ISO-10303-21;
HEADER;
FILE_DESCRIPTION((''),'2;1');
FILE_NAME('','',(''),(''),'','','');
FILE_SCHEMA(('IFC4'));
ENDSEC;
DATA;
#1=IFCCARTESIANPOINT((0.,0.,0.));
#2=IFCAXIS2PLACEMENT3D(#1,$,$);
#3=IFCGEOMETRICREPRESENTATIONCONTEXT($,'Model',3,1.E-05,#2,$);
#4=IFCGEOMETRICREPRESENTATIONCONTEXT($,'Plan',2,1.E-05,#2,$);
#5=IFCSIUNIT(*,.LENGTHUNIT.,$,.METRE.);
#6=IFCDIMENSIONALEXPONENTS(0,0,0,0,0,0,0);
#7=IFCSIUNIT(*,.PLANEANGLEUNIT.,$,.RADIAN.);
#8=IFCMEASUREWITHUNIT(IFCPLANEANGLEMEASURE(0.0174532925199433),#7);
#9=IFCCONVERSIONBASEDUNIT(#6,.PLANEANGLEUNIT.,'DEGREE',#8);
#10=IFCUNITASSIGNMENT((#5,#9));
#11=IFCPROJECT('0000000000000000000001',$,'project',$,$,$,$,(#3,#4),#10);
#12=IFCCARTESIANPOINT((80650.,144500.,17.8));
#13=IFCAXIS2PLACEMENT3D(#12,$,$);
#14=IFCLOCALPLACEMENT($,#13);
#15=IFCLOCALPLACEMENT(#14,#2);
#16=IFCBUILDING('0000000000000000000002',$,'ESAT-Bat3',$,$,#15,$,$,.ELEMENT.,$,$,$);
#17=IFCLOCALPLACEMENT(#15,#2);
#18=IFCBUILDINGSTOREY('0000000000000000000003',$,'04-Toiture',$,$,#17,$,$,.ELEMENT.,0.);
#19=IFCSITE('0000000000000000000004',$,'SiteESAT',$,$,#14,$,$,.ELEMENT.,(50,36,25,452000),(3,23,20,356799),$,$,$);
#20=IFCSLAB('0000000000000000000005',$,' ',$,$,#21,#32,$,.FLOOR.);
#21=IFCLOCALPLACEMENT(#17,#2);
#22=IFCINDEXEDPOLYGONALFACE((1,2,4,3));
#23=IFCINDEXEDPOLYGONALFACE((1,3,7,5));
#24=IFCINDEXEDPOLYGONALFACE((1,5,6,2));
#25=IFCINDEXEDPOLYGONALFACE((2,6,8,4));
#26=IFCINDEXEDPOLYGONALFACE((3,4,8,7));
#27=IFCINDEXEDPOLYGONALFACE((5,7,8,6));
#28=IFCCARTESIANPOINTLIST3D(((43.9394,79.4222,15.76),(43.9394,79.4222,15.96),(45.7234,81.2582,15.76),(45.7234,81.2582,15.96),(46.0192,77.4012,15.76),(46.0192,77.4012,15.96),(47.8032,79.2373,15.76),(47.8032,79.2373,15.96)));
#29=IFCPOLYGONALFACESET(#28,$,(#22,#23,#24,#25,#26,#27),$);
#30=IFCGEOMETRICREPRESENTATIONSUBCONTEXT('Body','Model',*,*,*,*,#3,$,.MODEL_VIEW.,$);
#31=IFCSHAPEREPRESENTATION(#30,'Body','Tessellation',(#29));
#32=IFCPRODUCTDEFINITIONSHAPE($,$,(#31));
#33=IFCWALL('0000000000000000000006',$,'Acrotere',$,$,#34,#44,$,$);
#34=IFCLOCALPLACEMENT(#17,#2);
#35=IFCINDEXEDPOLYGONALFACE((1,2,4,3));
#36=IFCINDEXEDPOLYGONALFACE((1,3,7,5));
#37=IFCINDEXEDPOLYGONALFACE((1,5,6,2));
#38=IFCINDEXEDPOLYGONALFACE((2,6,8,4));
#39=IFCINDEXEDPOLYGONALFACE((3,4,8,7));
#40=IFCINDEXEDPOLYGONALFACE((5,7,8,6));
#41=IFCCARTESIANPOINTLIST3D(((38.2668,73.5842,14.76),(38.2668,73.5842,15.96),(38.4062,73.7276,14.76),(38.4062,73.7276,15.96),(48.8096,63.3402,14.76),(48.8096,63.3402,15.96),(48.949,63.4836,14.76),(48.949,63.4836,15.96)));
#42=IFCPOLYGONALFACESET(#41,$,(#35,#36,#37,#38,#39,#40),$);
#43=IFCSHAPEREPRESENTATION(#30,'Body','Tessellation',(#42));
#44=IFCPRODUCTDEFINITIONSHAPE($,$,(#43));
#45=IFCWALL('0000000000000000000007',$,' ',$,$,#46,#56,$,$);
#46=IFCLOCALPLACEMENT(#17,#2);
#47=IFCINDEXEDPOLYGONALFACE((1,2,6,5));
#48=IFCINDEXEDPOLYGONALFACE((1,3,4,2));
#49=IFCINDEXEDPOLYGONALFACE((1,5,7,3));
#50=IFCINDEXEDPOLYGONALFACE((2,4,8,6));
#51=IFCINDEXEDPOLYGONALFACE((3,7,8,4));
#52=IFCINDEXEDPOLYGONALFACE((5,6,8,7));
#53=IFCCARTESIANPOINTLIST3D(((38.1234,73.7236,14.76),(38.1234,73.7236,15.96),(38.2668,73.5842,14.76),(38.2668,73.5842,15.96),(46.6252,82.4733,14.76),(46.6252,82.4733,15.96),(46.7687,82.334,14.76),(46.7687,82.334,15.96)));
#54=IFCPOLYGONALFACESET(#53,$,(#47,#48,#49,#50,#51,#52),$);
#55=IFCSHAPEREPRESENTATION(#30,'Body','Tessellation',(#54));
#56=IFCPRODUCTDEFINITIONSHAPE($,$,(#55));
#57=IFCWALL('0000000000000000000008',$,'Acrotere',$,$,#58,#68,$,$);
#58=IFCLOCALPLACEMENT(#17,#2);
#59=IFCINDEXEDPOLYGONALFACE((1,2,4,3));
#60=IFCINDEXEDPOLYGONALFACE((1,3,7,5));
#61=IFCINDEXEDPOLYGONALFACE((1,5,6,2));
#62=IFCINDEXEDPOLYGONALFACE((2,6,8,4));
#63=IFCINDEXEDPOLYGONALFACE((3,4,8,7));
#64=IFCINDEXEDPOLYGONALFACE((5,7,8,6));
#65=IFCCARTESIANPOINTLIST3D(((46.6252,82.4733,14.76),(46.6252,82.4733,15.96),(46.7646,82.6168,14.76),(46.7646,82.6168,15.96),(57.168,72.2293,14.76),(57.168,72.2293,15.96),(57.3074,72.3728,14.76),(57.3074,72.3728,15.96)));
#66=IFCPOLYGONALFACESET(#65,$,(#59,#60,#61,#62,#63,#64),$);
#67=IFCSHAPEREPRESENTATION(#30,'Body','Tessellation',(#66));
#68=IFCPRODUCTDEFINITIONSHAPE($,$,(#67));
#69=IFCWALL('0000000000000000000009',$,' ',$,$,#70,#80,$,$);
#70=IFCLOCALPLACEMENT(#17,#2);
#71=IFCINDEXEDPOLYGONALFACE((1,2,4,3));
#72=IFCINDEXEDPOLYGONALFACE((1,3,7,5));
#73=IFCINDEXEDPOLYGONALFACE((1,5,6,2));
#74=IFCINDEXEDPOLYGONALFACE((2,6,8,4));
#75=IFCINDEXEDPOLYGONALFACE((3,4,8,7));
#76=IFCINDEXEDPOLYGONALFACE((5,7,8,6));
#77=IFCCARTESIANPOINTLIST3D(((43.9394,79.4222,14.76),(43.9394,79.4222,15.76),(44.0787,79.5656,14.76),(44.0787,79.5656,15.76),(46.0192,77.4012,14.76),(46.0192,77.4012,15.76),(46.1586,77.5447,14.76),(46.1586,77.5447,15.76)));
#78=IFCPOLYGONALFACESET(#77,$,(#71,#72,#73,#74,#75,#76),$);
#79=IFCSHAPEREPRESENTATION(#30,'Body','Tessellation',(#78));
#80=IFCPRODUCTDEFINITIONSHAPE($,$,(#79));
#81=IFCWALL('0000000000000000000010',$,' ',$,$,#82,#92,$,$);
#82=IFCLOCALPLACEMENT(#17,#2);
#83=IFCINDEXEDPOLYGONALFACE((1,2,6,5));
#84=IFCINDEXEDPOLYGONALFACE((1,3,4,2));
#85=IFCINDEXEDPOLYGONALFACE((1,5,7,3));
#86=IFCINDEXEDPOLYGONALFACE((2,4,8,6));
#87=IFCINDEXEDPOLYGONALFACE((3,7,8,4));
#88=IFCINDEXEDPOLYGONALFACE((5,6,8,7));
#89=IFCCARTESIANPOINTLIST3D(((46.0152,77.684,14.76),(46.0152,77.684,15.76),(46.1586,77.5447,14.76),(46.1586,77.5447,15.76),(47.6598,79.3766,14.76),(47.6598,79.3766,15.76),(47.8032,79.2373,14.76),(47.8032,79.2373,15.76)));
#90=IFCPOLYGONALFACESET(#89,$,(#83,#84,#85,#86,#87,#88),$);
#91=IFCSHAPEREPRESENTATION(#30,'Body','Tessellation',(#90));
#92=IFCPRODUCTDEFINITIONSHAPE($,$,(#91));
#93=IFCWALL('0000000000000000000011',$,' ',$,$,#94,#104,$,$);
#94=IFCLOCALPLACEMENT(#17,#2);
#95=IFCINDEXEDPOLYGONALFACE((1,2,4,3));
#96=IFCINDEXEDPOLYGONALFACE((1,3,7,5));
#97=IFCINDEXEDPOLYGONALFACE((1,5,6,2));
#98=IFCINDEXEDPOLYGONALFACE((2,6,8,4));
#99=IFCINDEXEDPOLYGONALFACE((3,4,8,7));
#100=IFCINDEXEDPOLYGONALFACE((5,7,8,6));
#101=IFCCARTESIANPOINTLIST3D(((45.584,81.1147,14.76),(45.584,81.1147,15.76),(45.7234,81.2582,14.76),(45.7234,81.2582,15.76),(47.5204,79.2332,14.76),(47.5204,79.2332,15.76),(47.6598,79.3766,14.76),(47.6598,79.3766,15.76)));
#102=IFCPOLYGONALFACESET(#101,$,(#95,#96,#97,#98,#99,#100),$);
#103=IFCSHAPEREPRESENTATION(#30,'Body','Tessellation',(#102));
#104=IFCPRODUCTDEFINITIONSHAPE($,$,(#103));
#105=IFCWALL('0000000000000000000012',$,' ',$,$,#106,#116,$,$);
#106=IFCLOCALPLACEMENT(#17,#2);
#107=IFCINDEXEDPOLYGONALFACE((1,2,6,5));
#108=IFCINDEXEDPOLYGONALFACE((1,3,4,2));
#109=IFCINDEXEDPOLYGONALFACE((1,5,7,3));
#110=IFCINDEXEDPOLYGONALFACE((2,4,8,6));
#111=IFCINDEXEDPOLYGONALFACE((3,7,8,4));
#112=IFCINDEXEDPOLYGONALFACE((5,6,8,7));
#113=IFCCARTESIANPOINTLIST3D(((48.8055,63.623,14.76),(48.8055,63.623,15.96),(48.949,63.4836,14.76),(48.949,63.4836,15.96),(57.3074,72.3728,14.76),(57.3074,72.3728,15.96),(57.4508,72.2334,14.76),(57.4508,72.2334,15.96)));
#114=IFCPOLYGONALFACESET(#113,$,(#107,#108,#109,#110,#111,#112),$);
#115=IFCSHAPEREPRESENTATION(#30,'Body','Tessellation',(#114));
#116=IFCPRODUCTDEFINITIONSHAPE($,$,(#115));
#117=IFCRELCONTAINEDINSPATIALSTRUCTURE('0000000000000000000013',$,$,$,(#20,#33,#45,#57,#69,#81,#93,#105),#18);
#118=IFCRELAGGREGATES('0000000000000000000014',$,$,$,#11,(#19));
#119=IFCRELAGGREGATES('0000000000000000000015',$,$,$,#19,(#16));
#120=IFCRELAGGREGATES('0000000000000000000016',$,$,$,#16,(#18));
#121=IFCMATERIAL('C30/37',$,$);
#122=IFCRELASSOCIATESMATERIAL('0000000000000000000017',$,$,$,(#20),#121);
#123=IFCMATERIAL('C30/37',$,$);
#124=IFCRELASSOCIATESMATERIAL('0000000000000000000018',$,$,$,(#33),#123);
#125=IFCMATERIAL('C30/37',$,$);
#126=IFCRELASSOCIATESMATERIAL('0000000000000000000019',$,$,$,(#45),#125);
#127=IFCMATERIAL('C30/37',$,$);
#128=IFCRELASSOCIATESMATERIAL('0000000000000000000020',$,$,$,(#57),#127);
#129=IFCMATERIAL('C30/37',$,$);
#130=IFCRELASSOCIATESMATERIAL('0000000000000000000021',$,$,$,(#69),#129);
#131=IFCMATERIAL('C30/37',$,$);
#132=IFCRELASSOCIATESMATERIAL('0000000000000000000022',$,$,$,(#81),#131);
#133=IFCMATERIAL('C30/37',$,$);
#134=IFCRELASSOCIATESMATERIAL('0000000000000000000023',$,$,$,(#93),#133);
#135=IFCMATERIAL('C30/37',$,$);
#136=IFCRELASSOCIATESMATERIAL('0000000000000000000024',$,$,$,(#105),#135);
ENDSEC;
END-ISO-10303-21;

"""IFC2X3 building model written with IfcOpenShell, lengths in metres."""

from ifc_helpers import new_model, entity, si_unit, converted_unit, frame, frame_2d, origin, origin_with_axes, place, context, subcontext, project, spatial, rectangle, extrude, material, element, save


model = new_model("IFC2X3")

# Units and contexts
model_context = context("Model", 3, precision=1e-05, world=origin())
plan_context = context("Plan", 2, precision=1e-05, world=origin())
body_context = subcontext(model_context, "Body", "Model", "MODEL_VIEW")
ifc_project = project(units=[si_unit("LENGTHUNIT", "METRE"), converted_unit("PLANEANGLEUNIT", "DEGREE", entity("IfcPlaneAngleMeasure", 0.0174532925199433), si_unit("PLANEANGLEUNIT", "RADIAN"), dimensions=[0, 0, 0, 0, 0, 0, 0])], contexts=[model_context, plan_context])

# Site, building, storey
site_placement = place(None, frame((80650.0, 144500.0, 17.8)))
site = spatial("IfcSite", under=ifc_project, at=site_placement, Name="SiteESAT", CompositionType="ELEMENT", RefLatitude=(50, 36, 25, 452000), RefLongitude=(3, 23, 20, 356799))
building_placement = place(site_placement, origin())
building = spatial("IfcBuilding", under=site, at=building_placement, Name="ESAT-Bat3", CompositionType="ELEMENT")
storey_placement = place(building_placement, origin())
storey = spatial("IfcBuildingStorey", under=building, at=storey_placement, Name="04-Toiture", CompositionType="ELEMENT", Elevation=0.0)

# Slab
ifc_material_1 = material(Name="C30/37")
slab_placement = place(storey_placement, frame((43.9394, 77.4012, 15.76)))
element("IfcSlab", 1, at=slab_placement, inside=storey, material=ifc_material_1, Name=" ", PredefinedType="FLOOR", context=body_context, shape_type="SweptSolid", body=[
    extrude(rectangle(XDim=2.56, YDim=2.9, at=frame_2d((-0.1479, 1.9285), x_axis=(0.696872, 0.717196))), frame((2.0799, 0.0, 0.0), z_axis=(0.0, 0.0, 1.0), x_axis=(1.0, 0.0, 0.0)), (0.0, 0.0, 1.0), 0.2),
])

# Walls
ifc_material_2 = material(Name="C30/37")
wall_1_placement = place(storey_placement, frame((48.949, 63.4836, 14.76), z_axis=(0.0, 0.0, 1.0), x_axis=(-0.717196, 0.696872, 0.0)))
element("IfcWall", 2, at=wall_1_placement, inside=storey, material=ifc_material_2, Name="Acrotere", context=body_context, shape_type="SweptSolid", body=[
    extrude(rectangle(XDim=14.7, YDim=0.2, at=frame_2d((7.35, 0.1), x_axis=(1.0, 0.0))), origin_with_axes(), (0.0, 0.0, 1.0), 1.2),
])
ifc_material_3 = material(Name="C30/37")
wall_2_placement = place(storey_placement, frame((38.2668, 73.5842, 14.76), z_axis=(0.0, 0.0, 1.0), x_axis=(0.696872, 0.717196, 0.0)))
element("IfcWall", 3, at=wall_2_placement, inside=storey, material=ifc_material_3, Name=" ", context=body_context, shape_type="SweptSolid", body=[
    extrude(rectangle(XDim=12.2, YDim=0.2, at=frame_2d((6.1, 0.1), x_axis=(1.0, 0.0))), origin_with_axes(), (0.0, 0.0, 1.0), 1.2),
])
ifc_material_4 = material(Name="C30/37")
wall_3_placement = place(storey_placement, frame((46.6252, 82.4733, 14.76), z_axis=(0.0, 0.0, 1.0), x_axis=(0.717196, -0.696872, 0.0)))
element("IfcWall", 4, at=wall_3_placement, inside=storey, material=ifc_material_4, Name="Acrotere", context=body_context, shape_type="SweptSolid", body=[
    extrude(rectangle(XDim=14.7, YDim=0.2, at=frame_2d((7.35, 0.1), x_axis=(1.0, 0.0))), origin_with_axes(), (0.0, 0.0, 1.0), 1.2),
])
ifc_material_5 = material(Name="C30/37")
wall_4_placement = place(storey_placement, frame((46.1586, 77.5447, 14.76), z_axis=(0.0, 0.0, 1.0), x_axis=(-0.717196, 0.696872, 0.0)))
element("IfcWall", 5, at=wall_4_placement, inside=storey, material=ifc_material_5, Name=" ", context=body_context, shape_type="SweptSolid", body=[
    extrude(rectangle(XDim=2.9, YDim=0.2, at=frame_2d((1.45, 0.1), x_axis=(1.0, 0.0))), origin_with_axes(), (0.0, 0.0, 1.0), 1.0),
])
ifc_material_6 = material(Name="C30/37")
wall_5_placement = place(storey_placement, frame((47.6598, 79.3766, 14.76), z_axis=(0.0, 0.0, 1.0), x_axis=(-0.696872, -0.717196, 0.0)))
element("IfcWall", 6, at=wall_5_placement, inside=storey, material=ifc_material_6, Name=" ", context=body_context, shape_type="SweptSolid", body=[
    extrude(rectangle(XDim=2.36, YDim=0.2, at=frame_2d((1.18, 0.1), x_axis=(1.0, 0.0))), origin_with_axes(), (0.0, 0.0, 1.0), 1.0),
])
ifc_material_7 = material(Name="C30/37")
wall_6_placement = place(storey_placement, frame((45.584, 81.1147, 14.76), z_axis=(0.0, 0.0, 1.0), x_axis=(0.717196, -0.696872, 0.0)))
element("IfcWall", 7, at=wall_6_placement, inside=storey, material=ifc_material_7, Name=" ", context=body_context, shape_type="SweptSolid", body=[
    extrude(rectangle(XDim=2.7, YDim=0.2, at=frame_2d((1.35, 0.1), x_axis=(1.0, 0.0))), origin_with_axes(), (0.0, 0.0, 1.0), 1.0),
])
ifc_material_8 = material(Name="C30/37")
wall_7_placement = place(storey_placement, frame((57.3074, 72.3728, 14.76), z_axis=(0.0, 0.0, 1.0), x_axis=(-0.696872, -0.717196, 0.0)))
element("IfcWall", 8, at=wall_7_placement, inside=storey, material=ifc_material_8, Name=" ", context=body_context, shape_type="SweptSolid", body=[
    extrude(rectangle(XDim=12.2, YDim=0.2, at=frame_2d((6.1, 0.1), x_axis=(1.0, 0.0))), origin_with_axes(), (0.0, 0.0, 1.0), 1.2),
])

save(model, "model.ifc")
